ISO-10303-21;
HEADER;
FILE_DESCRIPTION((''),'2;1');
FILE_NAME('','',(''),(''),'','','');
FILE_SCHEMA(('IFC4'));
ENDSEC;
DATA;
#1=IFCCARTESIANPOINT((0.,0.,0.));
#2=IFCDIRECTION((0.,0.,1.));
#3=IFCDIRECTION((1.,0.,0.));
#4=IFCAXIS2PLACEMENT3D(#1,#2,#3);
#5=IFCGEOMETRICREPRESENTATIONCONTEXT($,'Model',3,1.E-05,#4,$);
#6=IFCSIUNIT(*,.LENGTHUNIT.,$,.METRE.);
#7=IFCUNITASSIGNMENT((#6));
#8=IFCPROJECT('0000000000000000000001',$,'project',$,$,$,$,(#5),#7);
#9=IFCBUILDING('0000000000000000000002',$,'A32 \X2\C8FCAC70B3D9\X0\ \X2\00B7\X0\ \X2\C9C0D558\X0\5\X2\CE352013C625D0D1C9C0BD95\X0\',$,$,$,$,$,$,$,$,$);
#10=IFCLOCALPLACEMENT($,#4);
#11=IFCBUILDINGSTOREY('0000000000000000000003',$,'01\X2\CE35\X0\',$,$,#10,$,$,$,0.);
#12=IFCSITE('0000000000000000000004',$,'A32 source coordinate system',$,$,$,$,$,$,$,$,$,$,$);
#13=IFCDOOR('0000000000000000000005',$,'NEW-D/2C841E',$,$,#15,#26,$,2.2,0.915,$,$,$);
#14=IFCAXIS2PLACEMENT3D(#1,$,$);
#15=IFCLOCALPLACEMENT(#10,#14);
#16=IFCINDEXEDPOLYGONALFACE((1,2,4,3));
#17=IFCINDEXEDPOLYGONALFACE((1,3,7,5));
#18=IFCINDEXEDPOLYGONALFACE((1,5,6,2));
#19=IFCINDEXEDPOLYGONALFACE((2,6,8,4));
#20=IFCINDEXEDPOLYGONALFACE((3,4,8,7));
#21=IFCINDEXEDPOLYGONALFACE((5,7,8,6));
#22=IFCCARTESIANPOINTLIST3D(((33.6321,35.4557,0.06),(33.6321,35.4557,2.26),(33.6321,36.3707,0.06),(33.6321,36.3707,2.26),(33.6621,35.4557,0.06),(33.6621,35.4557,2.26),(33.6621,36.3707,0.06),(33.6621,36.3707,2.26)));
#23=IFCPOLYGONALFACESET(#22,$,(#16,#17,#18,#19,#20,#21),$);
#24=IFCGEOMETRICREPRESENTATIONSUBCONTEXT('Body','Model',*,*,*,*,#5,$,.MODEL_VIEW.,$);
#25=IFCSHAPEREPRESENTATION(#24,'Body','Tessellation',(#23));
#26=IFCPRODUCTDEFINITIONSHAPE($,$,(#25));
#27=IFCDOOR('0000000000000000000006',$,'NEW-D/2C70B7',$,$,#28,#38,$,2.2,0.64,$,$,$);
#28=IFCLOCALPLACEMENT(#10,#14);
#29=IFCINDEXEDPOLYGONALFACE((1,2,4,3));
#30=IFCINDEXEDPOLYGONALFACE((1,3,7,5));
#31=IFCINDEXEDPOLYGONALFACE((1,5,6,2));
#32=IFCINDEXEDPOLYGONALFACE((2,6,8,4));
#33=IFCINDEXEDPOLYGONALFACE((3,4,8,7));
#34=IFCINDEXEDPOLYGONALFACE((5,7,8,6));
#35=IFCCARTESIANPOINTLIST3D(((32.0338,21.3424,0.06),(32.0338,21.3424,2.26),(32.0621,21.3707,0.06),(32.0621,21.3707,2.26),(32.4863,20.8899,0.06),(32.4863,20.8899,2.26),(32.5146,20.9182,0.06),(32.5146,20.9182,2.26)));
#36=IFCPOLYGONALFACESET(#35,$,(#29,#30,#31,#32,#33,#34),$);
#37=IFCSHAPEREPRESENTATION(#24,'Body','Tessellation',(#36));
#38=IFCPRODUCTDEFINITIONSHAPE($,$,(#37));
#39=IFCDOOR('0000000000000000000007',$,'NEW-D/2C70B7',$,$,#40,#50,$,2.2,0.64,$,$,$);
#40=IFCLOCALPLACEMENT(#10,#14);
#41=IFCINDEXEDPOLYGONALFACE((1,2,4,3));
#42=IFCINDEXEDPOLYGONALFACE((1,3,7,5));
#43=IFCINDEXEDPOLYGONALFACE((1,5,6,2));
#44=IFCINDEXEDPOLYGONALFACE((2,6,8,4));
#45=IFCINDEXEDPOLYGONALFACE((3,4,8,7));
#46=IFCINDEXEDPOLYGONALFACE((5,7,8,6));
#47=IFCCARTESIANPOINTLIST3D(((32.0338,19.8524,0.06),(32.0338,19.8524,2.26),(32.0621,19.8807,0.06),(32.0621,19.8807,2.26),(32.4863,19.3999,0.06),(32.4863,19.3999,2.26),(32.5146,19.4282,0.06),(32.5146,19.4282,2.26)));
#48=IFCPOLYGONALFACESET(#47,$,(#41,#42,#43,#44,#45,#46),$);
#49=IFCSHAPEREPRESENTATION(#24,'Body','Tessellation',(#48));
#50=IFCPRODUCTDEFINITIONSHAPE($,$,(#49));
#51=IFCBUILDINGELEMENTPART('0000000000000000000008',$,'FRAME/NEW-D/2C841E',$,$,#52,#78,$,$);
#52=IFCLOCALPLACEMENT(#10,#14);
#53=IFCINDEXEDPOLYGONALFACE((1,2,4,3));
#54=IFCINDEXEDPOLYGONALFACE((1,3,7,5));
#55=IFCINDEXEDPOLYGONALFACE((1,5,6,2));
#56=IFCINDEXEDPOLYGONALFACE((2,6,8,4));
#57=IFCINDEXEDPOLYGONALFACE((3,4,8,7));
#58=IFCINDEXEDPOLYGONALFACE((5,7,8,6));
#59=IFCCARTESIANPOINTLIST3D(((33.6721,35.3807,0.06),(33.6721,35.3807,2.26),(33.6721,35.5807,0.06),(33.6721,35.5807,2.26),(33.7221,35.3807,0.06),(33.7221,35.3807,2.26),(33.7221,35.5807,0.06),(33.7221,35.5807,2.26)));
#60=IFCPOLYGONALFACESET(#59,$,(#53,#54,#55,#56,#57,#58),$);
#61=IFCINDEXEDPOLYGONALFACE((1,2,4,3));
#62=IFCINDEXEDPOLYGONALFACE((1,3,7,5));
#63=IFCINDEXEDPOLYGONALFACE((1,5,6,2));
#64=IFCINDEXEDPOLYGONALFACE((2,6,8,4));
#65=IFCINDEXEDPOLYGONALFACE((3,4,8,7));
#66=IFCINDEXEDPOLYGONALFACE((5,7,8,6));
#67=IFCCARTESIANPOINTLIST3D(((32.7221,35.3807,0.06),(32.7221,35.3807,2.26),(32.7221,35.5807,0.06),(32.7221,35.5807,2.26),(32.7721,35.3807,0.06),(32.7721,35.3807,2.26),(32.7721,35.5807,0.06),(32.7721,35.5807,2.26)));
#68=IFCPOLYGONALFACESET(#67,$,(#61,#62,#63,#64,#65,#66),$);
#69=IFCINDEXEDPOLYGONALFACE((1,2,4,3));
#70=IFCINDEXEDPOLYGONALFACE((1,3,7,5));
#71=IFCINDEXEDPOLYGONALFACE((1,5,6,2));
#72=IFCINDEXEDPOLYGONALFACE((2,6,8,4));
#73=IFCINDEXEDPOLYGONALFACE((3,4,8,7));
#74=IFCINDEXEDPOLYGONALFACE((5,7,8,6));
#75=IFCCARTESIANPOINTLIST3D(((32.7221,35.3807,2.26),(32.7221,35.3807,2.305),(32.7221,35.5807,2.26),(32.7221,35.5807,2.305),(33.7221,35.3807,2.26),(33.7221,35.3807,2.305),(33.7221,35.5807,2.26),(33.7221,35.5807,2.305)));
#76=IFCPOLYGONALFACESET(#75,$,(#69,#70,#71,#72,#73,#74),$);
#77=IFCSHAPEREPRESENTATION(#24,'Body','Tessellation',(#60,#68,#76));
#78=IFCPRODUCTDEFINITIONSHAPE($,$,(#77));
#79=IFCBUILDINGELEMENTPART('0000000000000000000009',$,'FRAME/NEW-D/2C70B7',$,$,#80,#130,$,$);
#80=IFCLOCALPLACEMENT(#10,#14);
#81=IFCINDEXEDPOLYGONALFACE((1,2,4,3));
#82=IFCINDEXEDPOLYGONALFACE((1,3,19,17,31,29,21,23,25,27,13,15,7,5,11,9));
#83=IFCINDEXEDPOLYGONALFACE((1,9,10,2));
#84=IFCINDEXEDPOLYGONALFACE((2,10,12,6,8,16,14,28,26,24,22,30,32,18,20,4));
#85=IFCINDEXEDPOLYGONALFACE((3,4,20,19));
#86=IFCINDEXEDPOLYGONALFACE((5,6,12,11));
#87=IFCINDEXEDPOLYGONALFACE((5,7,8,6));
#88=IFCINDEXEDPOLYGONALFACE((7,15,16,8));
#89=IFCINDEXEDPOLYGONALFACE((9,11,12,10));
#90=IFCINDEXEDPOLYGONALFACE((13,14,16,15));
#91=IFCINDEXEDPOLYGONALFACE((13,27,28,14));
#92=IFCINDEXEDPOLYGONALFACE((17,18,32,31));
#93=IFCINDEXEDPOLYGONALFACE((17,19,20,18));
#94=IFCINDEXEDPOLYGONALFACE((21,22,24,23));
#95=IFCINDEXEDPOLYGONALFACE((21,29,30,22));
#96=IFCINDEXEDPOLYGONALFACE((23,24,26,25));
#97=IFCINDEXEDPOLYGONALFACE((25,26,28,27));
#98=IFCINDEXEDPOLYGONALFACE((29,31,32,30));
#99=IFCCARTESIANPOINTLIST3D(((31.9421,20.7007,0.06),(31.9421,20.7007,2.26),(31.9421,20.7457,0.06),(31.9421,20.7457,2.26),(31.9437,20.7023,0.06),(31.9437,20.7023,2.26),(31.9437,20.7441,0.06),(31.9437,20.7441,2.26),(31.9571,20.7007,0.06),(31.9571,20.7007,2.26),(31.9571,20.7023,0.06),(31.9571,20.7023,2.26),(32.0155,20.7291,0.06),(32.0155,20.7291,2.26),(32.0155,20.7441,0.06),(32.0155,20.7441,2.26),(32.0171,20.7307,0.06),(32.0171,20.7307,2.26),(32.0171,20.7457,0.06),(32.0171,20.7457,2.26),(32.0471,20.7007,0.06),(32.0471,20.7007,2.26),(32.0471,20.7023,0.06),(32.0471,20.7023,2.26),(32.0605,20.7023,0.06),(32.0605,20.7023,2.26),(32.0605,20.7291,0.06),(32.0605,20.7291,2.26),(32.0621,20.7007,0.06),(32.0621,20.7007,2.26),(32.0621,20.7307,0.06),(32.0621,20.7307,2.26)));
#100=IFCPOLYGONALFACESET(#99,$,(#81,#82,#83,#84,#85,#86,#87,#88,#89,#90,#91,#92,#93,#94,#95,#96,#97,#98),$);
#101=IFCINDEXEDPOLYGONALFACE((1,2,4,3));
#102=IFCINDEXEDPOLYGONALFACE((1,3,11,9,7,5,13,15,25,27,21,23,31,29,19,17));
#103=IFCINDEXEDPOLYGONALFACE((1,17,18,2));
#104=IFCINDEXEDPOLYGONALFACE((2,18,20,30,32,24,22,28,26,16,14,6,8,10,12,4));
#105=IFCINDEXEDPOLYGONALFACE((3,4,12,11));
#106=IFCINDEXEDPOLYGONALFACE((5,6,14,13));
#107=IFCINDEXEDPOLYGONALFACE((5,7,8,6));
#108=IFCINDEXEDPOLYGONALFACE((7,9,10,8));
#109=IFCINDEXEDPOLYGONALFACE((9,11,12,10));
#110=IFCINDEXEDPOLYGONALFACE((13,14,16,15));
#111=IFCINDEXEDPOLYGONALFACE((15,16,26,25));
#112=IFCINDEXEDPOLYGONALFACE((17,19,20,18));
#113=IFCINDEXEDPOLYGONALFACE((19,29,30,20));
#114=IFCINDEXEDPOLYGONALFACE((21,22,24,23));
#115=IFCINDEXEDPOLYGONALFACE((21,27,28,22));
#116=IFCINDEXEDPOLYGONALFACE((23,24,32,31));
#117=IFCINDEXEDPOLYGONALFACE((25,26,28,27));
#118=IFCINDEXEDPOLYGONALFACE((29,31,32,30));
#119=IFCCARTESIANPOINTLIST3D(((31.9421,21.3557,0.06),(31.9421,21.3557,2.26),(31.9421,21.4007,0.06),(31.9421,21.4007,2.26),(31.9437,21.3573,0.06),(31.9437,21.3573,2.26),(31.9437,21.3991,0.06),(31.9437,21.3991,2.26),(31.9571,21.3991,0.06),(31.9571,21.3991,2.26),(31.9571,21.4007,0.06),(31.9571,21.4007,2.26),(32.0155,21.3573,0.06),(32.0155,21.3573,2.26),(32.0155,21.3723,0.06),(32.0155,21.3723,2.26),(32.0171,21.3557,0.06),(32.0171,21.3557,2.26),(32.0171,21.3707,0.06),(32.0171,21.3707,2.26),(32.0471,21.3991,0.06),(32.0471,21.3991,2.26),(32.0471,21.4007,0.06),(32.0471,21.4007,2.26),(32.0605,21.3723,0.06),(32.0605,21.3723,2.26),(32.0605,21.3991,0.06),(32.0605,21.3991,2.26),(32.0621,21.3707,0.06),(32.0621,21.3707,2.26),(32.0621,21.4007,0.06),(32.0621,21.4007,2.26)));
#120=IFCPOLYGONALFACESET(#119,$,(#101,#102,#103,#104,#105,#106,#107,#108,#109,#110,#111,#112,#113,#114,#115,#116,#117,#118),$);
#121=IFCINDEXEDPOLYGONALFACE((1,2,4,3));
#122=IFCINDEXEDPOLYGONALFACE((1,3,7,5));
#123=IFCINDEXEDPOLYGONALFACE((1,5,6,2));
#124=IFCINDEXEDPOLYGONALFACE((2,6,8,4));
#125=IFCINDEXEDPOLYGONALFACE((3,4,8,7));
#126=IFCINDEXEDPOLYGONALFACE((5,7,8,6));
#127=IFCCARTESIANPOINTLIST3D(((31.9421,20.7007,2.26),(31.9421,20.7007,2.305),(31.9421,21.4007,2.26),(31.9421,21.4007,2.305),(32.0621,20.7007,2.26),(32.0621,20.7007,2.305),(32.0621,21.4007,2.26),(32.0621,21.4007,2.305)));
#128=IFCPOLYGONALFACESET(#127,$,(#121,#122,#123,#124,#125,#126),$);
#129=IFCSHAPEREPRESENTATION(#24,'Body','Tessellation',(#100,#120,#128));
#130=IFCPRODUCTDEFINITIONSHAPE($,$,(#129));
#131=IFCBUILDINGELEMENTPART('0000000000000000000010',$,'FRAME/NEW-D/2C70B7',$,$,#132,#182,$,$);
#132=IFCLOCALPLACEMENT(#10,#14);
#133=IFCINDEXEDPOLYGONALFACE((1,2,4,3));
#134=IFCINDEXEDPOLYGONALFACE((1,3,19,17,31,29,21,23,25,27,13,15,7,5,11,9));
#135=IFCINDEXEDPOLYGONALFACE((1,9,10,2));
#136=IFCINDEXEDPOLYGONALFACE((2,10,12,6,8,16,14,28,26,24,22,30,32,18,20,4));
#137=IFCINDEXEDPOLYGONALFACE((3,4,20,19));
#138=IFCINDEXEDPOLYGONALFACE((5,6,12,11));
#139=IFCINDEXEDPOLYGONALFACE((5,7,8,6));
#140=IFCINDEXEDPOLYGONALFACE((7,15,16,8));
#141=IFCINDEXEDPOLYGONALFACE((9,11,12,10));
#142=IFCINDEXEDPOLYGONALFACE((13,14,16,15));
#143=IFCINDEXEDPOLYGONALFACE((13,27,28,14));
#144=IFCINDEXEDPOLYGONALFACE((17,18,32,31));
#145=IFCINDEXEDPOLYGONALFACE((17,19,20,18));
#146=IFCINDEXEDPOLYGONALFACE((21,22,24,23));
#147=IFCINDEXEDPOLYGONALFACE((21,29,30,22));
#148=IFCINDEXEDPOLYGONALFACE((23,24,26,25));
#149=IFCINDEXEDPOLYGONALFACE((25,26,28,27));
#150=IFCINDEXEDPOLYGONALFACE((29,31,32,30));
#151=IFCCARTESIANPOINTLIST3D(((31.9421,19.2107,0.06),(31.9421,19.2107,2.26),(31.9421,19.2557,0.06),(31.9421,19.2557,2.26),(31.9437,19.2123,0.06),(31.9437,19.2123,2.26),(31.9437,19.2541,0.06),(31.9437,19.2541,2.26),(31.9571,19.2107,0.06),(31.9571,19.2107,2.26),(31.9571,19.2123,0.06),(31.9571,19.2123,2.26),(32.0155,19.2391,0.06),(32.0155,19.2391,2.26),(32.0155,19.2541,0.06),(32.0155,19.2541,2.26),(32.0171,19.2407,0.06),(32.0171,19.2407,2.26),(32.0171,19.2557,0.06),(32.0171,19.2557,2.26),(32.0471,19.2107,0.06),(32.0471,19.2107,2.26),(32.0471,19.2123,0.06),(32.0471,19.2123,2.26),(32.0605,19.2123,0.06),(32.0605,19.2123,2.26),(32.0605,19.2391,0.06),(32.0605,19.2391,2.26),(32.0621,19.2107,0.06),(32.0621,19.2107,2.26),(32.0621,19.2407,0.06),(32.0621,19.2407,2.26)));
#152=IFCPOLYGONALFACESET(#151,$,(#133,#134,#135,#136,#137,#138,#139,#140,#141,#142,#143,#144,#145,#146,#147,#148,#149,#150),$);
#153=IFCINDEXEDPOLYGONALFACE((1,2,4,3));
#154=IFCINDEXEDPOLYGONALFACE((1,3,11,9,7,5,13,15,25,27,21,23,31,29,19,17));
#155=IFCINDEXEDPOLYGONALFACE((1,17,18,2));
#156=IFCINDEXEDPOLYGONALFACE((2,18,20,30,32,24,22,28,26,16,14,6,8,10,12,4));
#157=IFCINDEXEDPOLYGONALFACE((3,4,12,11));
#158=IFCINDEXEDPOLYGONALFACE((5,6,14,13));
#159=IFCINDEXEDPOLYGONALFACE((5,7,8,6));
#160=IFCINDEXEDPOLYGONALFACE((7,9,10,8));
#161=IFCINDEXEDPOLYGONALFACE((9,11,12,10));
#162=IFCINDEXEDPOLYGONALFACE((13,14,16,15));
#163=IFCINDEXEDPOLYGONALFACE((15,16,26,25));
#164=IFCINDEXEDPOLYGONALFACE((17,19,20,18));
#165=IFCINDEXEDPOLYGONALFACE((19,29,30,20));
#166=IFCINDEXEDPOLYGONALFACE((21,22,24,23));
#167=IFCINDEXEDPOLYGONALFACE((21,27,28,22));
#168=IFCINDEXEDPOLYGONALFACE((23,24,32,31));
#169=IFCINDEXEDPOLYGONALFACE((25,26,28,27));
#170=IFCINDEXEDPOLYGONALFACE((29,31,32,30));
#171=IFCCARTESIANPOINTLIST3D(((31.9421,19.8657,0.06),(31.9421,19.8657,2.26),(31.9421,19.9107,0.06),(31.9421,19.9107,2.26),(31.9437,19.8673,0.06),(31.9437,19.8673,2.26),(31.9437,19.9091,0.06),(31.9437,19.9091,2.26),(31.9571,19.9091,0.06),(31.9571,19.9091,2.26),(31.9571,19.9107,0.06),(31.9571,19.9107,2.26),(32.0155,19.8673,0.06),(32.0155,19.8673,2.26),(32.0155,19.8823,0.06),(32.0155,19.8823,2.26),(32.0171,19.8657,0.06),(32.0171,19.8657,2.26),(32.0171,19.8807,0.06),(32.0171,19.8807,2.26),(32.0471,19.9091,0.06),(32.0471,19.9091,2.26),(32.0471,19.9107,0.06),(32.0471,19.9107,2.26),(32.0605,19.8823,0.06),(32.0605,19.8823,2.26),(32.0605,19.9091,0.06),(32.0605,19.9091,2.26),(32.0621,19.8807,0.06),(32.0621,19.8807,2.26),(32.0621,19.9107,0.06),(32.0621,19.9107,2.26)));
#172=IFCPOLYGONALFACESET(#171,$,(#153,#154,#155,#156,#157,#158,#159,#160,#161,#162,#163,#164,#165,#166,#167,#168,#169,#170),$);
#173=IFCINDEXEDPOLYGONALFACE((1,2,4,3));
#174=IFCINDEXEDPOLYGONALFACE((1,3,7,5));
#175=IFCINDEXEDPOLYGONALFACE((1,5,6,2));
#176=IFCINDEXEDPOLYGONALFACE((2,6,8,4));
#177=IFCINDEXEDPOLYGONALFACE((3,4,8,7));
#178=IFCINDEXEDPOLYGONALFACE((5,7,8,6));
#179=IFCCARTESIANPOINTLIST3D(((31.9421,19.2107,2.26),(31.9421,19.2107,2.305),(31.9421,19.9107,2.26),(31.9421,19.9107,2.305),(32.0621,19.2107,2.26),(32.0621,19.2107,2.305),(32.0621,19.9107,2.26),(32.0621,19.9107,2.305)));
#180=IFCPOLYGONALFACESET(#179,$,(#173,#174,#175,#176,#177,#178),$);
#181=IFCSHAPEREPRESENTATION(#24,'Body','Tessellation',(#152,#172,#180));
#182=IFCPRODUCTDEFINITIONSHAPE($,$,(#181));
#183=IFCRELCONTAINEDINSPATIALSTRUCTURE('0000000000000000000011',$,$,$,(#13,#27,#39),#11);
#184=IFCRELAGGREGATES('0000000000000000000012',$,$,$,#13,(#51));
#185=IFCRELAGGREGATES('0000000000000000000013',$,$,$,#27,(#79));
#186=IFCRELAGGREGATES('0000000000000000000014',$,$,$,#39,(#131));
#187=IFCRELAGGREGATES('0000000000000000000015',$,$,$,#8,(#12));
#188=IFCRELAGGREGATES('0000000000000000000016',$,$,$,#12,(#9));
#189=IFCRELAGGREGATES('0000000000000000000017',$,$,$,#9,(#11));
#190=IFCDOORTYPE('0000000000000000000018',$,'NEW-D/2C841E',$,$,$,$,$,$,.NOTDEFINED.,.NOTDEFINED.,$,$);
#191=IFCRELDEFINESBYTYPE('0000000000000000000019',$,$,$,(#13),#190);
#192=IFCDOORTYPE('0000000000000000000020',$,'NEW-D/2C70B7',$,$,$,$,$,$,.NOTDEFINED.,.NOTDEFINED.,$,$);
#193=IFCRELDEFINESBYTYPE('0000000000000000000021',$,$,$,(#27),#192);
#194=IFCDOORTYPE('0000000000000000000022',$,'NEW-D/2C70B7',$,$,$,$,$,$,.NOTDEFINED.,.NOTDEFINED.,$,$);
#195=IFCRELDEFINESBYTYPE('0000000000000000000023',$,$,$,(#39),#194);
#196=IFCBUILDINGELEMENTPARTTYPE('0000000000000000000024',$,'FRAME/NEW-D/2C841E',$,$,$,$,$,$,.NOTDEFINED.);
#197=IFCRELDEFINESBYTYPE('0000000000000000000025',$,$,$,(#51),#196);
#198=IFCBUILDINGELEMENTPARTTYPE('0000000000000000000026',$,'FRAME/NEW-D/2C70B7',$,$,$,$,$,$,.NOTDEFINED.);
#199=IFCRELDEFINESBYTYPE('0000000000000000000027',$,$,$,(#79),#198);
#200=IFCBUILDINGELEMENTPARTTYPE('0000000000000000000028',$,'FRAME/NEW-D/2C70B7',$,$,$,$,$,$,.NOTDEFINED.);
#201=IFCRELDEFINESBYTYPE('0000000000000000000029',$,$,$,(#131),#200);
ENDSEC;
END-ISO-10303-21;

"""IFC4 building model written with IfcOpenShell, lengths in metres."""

from ifc_helpers import new_model, si_unit, frame, origin, origin_with_axes, place, context, subcontext, project, spatial, polyline, outline, extrude, source, transform, mapped, type_object, type_shapes, element, aggregate, save


model = new_model("IFC4")

# Units and contexts
model_context = context("Model", 3, precision=1e-05, world=origin_with_axes())
body_context = subcontext(model_context, "Body", "Model", "MODEL_VIEW")
ifc_project = project(units=[si_unit("LENGTHUNIT", "METRE")], contexts=[model_context])

# Site, building, storey
site = spatial("IfcSite", under=ifc_project, Name="A32 source coordinate system")
building = spatial("IfcBuilding", under=site, Name="A32 주거동 · 지하5층–옥탑지붕")
storey_placement = place(None, origin_with_axes())
storey = spatial("IfcBuildingStorey", under=building, at=storey_placement, Name="01층", Elevation=0.0)

# Doors
door_type_1 = type_object("IfcDoorType", Name="NEW-D/2C841E", OperationType="NOTDEFINED", PredefinedType="NOTDEFINED")
shared_shape_1 = source(origin(), body_context, "Body", "SweptSolid", [
    extrude(outline(polyline([(33.6321, 35.4557), (33.6321, 36.3707), (33.6621, 36.3707), (33.6621, 35.4557), (33.6321, 35.4557)])), frame((0.0, 0.0, 0.06)), (0.0, 0.0, 1.0), 2.2),
])
type_shapes(door_type_1, [shared_shape_1])
door_1_placement = place(storey_placement, origin_with_axes())
door_1 = element("IfcDoor", 1, at=door_1_placement, inside=storey, type_object=door_type_1, Name="NEW-D/2C841E", OverallHeight=2.2, OverallWidth=0.915, context=body_context, shape_type="MappedRepresentation", body=[
    mapped(shared_shape_1, transform((0.0, 0.0, 0.0), scale=1.0)),
])
door_type_2 = type_object("IfcDoorType", Name="NEW-D/2C70B7", OperationType="NOTDEFINED", PredefinedType="NOTDEFINED")
shared_shape_2 = source(origin(), body_context, "Body", "SweptSolid", [
    extrude(outline(polyline([(32.4863, 20.8899), (32.0338, 21.3424), (32.0621, 21.3707), (32.5146, 20.9182), (32.4863, 20.8899)])), frame((0.0, 0.0, 0.06)), (0.0, 0.0, 1.0), 2.2),
])
type_shapes(door_type_2, [shared_shape_2])
door_2_placement = place(storey_placement, origin_with_axes())
door_2 = element("IfcDoor", 2, at=door_2_placement, inside=storey, type_object=door_type_2, Name="NEW-D/2C70B7", OverallHeight=2.2, OverallWidth=0.64, context=body_context, shape_type="MappedRepresentation", body=[
    mapped(shared_shape_2, transform((0.0, 0.0, 0.0), scale=1.0)),
])
door_type_3 = type_object("IfcDoorType", Name="NEW-D/2C70B7", OperationType="NOTDEFINED", PredefinedType="NOTDEFINED")
shared_shape_3 = source(origin(), body_context, "Body", "SweptSolid", [
    extrude(outline(polyline([(32.4863, 19.3999), (32.0338, 19.8524), (32.0621, 19.8807), (32.5146, 19.4282), (32.4863, 19.3999)])), frame((0.0, 0.0, 0.06)), (0.0, 0.0, 1.0), 2.2),
])
type_shapes(door_type_3, [shared_shape_3])
door_3_placement = place(storey_placement, origin_with_axes())
door_3 = element("IfcDoor", 3, at=door_3_placement, inside=storey, type_object=door_type_3, Name="NEW-D/2C70B7", OverallHeight=2.2, OverallWidth=0.64, context=body_context, shape_type="MappedRepresentation", body=[
    mapped(shared_shape_3, transform((0.0, 0.0, 0.0), scale=1.0)),
])

# Building element parts
building_element_part_type_1 = type_object("IfcBuildingElementPartType", Name="FRAME/NEW-D/2C841E", PredefinedType="NOTDEFINED")
shared_shape_4 = source(origin(), body_context, "Body", "SweptSolid", [
    extrude(outline(polyline([(33.6721, 35.5807), (33.7221, 35.5807), (33.7221, 35.3807), (33.6721, 35.3807), (33.6721, 35.5807)])), frame((0.0, 0.0, 0.06)), (0.0, 0.0, 1.0), 2.2),
    extrude(outline(polyline([(32.7221, 35.5807), (32.7721, 35.5807), (32.7721, 35.3807), (32.7221, 35.3807), (32.7221, 35.5807)])), frame((0.0, 0.0, 0.06)), (0.0, 0.0, 1.0), 2.2),
    extrude(outline(polyline([(33.7221, 35.3807), (33.7221, 35.5807), (32.7221, 35.5807), (32.7221, 35.3807), (33.7221, 35.3807)])), frame((0.0, 0.0, 2.26)), (0.0, 0.0, 1.0), 0.045),
])
type_shapes(building_element_part_type_1, [shared_shape_4])
building_element_part_1_placement = place(door_1_placement, origin_with_axes())
building_element_part_1 = element("IfcBuildingElementPart", 4, at=building_element_part_1_placement, type_object=building_element_part_type_1, Name="FRAME/NEW-D/2C841E", context=body_context, shape_type="MappedRepresentation", body=[
    mapped(shared_shape_4, transform((0.0, 0.0, 0.0), scale=1.0)),
])
aggregate(door_1, [building_element_part_1])
building_element_part_type_2 = type_object("IfcBuildingElementPartType", Name="FRAME/NEW-D/2C70B7", PredefinedType="NOTDEFINED")
shared_shape_5 = source(origin(), body_context, "Body", "SweptSolid", [
    extrude(outline(polyline([(32.0605, 20.7291), (32.0155, 20.7291), (32.0155, 20.7441), (31.9437, 20.7441), (31.9437, 20.7023), (31.9571, 20.7023), (31.9571, 20.7007), (31.9421, 20.7007), (31.9421, 20.7457), (32.0171, 20.7457), (32.0171, 20.7307), (32.0621, 20.7307), (32.0621, 20.7007), (32.0471, 20.7007), (32.0471, 20.7023), (32.0605, 20.7023), (32.0605, 20.7291)])), frame((0.0, 0.0, 0.06)), (0.0, 0.0, 1.0), 2.2),
    extrude(outline(polyline([(32.0621, 21.4007), (32.0621, 21.3707), (32.0171, 21.3707), (32.0171, 21.3557), (31.9421, 21.3557), (31.9421, 21.4007), (31.9571, 21.4007), (31.9571, 21.3991), (31.9437, 21.3991), (31.9437, 21.3573), (32.0155, 21.3573), (32.0155, 21.3723), (32.0605, 21.3723), (32.0605, 21.3991), (32.0471, 21.3991), (32.0471, 21.4007), (32.0621, 21.4007)])), frame((0.0, 0.0, 0.06)), (0.0, 0.0, 1.0), 2.2),
    extrude(outline(polyline([(32.0621, 20.7007), (32.0621, 21.4007), (31.9421, 21.4007), (31.9421, 20.7007), (32.0621, 20.7007)])), frame((0.0, 0.0, 2.26)), (0.0, 0.0, 1.0), 0.045),
])
type_shapes(building_element_part_type_2, [shared_shape_5])
building_element_part_2_placement = place(door_2_placement, origin_with_axes())
building_element_part_2 = element("IfcBuildingElementPart", 5, at=building_element_part_2_placement, type_object=building_element_part_type_2, Name="FRAME/NEW-D/2C70B7", context=body_context, shape_type="MappedRepresentation", body=[
    mapped(shared_shape_5, transform((0.0, 0.0, 0.0), scale=1.0)),
])
aggregate(door_2, [building_element_part_2])
building_element_part_type_3 = type_object("IfcBuildingElementPartType", Name="FRAME/NEW-D/2C70B7", PredefinedType="NOTDEFINED")
shared_shape_6 = source(origin(), body_context, "Body", "SweptSolid", [
    extrude(outline(polyline([(32.0605, 19.2391), (32.0155, 19.2391), (32.0155, 19.2541), (31.9437, 19.2541), (31.9437, 19.2123), (31.9571, 19.2123), (31.9571, 19.2107), (31.9421, 19.2107), (31.9421, 19.2557), (32.0171, 19.2557), (32.0171, 19.2407), (32.0621, 19.2407), (32.0621, 19.2107), (32.0471, 19.2107), (32.0471, 19.2123), (32.0605, 19.2123), (32.0605, 19.2391)])), frame((0.0, 0.0, 0.06)), (0.0, 0.0, 1.0), 2.2),
    extrude(outline(polyline([(32.0621, 19.9107), (32.0621, 19.8807), (32.0171, 19.8807), (32.0171, 19.8657), (31.9421, 19.8657), (31.9421, 19.9107), (31.9571, 19.9107), (31.9571, 19.9091), (31.9437, 19.9091), (31.9437, 19.8673), (32.0155, 19.8673), (32.0155, 19.8823), (32.0605, 19.8823), (32.0605, 19.9091), (32.0471, 19.9091), (32.0471, 19.9107), (32.0621, 19.9107)])), frame((0.0, 0.0, 0.06)), (0.0, 0.0, 1.0), 2.2),
    extrude(outline(polyline([(32.0621, 19.2107), (32.0621, 19.9107), (31.9421, 19.9107), (31.9421, 19.2107), (32.0621, 19.2107)])), frame((0.0, 0.0, 2.26)), (0.0, 0.0, 1.0), 0.045),
])
type_shapes(building_element_part_type_3, [shared_shape_6])
building_element_part_3_placement = place(door_3_placement, origin_with_axes())
building_element_part_3 = element("IfcBuildingElementPart", 6, at=building_element_part_3_placement, type_object=building_element_part_type_3, Name="FRAME/NEW-D/2C70B7", context=body_context, shape_type="MappedRepresentation", body=[
    mapped(shared_shape_6, transform((0.0, 0.0, 0.0), scale=1.0)),
])
aggregate(door_3, [building_element_part_3])

save(model, "model.ifc")
